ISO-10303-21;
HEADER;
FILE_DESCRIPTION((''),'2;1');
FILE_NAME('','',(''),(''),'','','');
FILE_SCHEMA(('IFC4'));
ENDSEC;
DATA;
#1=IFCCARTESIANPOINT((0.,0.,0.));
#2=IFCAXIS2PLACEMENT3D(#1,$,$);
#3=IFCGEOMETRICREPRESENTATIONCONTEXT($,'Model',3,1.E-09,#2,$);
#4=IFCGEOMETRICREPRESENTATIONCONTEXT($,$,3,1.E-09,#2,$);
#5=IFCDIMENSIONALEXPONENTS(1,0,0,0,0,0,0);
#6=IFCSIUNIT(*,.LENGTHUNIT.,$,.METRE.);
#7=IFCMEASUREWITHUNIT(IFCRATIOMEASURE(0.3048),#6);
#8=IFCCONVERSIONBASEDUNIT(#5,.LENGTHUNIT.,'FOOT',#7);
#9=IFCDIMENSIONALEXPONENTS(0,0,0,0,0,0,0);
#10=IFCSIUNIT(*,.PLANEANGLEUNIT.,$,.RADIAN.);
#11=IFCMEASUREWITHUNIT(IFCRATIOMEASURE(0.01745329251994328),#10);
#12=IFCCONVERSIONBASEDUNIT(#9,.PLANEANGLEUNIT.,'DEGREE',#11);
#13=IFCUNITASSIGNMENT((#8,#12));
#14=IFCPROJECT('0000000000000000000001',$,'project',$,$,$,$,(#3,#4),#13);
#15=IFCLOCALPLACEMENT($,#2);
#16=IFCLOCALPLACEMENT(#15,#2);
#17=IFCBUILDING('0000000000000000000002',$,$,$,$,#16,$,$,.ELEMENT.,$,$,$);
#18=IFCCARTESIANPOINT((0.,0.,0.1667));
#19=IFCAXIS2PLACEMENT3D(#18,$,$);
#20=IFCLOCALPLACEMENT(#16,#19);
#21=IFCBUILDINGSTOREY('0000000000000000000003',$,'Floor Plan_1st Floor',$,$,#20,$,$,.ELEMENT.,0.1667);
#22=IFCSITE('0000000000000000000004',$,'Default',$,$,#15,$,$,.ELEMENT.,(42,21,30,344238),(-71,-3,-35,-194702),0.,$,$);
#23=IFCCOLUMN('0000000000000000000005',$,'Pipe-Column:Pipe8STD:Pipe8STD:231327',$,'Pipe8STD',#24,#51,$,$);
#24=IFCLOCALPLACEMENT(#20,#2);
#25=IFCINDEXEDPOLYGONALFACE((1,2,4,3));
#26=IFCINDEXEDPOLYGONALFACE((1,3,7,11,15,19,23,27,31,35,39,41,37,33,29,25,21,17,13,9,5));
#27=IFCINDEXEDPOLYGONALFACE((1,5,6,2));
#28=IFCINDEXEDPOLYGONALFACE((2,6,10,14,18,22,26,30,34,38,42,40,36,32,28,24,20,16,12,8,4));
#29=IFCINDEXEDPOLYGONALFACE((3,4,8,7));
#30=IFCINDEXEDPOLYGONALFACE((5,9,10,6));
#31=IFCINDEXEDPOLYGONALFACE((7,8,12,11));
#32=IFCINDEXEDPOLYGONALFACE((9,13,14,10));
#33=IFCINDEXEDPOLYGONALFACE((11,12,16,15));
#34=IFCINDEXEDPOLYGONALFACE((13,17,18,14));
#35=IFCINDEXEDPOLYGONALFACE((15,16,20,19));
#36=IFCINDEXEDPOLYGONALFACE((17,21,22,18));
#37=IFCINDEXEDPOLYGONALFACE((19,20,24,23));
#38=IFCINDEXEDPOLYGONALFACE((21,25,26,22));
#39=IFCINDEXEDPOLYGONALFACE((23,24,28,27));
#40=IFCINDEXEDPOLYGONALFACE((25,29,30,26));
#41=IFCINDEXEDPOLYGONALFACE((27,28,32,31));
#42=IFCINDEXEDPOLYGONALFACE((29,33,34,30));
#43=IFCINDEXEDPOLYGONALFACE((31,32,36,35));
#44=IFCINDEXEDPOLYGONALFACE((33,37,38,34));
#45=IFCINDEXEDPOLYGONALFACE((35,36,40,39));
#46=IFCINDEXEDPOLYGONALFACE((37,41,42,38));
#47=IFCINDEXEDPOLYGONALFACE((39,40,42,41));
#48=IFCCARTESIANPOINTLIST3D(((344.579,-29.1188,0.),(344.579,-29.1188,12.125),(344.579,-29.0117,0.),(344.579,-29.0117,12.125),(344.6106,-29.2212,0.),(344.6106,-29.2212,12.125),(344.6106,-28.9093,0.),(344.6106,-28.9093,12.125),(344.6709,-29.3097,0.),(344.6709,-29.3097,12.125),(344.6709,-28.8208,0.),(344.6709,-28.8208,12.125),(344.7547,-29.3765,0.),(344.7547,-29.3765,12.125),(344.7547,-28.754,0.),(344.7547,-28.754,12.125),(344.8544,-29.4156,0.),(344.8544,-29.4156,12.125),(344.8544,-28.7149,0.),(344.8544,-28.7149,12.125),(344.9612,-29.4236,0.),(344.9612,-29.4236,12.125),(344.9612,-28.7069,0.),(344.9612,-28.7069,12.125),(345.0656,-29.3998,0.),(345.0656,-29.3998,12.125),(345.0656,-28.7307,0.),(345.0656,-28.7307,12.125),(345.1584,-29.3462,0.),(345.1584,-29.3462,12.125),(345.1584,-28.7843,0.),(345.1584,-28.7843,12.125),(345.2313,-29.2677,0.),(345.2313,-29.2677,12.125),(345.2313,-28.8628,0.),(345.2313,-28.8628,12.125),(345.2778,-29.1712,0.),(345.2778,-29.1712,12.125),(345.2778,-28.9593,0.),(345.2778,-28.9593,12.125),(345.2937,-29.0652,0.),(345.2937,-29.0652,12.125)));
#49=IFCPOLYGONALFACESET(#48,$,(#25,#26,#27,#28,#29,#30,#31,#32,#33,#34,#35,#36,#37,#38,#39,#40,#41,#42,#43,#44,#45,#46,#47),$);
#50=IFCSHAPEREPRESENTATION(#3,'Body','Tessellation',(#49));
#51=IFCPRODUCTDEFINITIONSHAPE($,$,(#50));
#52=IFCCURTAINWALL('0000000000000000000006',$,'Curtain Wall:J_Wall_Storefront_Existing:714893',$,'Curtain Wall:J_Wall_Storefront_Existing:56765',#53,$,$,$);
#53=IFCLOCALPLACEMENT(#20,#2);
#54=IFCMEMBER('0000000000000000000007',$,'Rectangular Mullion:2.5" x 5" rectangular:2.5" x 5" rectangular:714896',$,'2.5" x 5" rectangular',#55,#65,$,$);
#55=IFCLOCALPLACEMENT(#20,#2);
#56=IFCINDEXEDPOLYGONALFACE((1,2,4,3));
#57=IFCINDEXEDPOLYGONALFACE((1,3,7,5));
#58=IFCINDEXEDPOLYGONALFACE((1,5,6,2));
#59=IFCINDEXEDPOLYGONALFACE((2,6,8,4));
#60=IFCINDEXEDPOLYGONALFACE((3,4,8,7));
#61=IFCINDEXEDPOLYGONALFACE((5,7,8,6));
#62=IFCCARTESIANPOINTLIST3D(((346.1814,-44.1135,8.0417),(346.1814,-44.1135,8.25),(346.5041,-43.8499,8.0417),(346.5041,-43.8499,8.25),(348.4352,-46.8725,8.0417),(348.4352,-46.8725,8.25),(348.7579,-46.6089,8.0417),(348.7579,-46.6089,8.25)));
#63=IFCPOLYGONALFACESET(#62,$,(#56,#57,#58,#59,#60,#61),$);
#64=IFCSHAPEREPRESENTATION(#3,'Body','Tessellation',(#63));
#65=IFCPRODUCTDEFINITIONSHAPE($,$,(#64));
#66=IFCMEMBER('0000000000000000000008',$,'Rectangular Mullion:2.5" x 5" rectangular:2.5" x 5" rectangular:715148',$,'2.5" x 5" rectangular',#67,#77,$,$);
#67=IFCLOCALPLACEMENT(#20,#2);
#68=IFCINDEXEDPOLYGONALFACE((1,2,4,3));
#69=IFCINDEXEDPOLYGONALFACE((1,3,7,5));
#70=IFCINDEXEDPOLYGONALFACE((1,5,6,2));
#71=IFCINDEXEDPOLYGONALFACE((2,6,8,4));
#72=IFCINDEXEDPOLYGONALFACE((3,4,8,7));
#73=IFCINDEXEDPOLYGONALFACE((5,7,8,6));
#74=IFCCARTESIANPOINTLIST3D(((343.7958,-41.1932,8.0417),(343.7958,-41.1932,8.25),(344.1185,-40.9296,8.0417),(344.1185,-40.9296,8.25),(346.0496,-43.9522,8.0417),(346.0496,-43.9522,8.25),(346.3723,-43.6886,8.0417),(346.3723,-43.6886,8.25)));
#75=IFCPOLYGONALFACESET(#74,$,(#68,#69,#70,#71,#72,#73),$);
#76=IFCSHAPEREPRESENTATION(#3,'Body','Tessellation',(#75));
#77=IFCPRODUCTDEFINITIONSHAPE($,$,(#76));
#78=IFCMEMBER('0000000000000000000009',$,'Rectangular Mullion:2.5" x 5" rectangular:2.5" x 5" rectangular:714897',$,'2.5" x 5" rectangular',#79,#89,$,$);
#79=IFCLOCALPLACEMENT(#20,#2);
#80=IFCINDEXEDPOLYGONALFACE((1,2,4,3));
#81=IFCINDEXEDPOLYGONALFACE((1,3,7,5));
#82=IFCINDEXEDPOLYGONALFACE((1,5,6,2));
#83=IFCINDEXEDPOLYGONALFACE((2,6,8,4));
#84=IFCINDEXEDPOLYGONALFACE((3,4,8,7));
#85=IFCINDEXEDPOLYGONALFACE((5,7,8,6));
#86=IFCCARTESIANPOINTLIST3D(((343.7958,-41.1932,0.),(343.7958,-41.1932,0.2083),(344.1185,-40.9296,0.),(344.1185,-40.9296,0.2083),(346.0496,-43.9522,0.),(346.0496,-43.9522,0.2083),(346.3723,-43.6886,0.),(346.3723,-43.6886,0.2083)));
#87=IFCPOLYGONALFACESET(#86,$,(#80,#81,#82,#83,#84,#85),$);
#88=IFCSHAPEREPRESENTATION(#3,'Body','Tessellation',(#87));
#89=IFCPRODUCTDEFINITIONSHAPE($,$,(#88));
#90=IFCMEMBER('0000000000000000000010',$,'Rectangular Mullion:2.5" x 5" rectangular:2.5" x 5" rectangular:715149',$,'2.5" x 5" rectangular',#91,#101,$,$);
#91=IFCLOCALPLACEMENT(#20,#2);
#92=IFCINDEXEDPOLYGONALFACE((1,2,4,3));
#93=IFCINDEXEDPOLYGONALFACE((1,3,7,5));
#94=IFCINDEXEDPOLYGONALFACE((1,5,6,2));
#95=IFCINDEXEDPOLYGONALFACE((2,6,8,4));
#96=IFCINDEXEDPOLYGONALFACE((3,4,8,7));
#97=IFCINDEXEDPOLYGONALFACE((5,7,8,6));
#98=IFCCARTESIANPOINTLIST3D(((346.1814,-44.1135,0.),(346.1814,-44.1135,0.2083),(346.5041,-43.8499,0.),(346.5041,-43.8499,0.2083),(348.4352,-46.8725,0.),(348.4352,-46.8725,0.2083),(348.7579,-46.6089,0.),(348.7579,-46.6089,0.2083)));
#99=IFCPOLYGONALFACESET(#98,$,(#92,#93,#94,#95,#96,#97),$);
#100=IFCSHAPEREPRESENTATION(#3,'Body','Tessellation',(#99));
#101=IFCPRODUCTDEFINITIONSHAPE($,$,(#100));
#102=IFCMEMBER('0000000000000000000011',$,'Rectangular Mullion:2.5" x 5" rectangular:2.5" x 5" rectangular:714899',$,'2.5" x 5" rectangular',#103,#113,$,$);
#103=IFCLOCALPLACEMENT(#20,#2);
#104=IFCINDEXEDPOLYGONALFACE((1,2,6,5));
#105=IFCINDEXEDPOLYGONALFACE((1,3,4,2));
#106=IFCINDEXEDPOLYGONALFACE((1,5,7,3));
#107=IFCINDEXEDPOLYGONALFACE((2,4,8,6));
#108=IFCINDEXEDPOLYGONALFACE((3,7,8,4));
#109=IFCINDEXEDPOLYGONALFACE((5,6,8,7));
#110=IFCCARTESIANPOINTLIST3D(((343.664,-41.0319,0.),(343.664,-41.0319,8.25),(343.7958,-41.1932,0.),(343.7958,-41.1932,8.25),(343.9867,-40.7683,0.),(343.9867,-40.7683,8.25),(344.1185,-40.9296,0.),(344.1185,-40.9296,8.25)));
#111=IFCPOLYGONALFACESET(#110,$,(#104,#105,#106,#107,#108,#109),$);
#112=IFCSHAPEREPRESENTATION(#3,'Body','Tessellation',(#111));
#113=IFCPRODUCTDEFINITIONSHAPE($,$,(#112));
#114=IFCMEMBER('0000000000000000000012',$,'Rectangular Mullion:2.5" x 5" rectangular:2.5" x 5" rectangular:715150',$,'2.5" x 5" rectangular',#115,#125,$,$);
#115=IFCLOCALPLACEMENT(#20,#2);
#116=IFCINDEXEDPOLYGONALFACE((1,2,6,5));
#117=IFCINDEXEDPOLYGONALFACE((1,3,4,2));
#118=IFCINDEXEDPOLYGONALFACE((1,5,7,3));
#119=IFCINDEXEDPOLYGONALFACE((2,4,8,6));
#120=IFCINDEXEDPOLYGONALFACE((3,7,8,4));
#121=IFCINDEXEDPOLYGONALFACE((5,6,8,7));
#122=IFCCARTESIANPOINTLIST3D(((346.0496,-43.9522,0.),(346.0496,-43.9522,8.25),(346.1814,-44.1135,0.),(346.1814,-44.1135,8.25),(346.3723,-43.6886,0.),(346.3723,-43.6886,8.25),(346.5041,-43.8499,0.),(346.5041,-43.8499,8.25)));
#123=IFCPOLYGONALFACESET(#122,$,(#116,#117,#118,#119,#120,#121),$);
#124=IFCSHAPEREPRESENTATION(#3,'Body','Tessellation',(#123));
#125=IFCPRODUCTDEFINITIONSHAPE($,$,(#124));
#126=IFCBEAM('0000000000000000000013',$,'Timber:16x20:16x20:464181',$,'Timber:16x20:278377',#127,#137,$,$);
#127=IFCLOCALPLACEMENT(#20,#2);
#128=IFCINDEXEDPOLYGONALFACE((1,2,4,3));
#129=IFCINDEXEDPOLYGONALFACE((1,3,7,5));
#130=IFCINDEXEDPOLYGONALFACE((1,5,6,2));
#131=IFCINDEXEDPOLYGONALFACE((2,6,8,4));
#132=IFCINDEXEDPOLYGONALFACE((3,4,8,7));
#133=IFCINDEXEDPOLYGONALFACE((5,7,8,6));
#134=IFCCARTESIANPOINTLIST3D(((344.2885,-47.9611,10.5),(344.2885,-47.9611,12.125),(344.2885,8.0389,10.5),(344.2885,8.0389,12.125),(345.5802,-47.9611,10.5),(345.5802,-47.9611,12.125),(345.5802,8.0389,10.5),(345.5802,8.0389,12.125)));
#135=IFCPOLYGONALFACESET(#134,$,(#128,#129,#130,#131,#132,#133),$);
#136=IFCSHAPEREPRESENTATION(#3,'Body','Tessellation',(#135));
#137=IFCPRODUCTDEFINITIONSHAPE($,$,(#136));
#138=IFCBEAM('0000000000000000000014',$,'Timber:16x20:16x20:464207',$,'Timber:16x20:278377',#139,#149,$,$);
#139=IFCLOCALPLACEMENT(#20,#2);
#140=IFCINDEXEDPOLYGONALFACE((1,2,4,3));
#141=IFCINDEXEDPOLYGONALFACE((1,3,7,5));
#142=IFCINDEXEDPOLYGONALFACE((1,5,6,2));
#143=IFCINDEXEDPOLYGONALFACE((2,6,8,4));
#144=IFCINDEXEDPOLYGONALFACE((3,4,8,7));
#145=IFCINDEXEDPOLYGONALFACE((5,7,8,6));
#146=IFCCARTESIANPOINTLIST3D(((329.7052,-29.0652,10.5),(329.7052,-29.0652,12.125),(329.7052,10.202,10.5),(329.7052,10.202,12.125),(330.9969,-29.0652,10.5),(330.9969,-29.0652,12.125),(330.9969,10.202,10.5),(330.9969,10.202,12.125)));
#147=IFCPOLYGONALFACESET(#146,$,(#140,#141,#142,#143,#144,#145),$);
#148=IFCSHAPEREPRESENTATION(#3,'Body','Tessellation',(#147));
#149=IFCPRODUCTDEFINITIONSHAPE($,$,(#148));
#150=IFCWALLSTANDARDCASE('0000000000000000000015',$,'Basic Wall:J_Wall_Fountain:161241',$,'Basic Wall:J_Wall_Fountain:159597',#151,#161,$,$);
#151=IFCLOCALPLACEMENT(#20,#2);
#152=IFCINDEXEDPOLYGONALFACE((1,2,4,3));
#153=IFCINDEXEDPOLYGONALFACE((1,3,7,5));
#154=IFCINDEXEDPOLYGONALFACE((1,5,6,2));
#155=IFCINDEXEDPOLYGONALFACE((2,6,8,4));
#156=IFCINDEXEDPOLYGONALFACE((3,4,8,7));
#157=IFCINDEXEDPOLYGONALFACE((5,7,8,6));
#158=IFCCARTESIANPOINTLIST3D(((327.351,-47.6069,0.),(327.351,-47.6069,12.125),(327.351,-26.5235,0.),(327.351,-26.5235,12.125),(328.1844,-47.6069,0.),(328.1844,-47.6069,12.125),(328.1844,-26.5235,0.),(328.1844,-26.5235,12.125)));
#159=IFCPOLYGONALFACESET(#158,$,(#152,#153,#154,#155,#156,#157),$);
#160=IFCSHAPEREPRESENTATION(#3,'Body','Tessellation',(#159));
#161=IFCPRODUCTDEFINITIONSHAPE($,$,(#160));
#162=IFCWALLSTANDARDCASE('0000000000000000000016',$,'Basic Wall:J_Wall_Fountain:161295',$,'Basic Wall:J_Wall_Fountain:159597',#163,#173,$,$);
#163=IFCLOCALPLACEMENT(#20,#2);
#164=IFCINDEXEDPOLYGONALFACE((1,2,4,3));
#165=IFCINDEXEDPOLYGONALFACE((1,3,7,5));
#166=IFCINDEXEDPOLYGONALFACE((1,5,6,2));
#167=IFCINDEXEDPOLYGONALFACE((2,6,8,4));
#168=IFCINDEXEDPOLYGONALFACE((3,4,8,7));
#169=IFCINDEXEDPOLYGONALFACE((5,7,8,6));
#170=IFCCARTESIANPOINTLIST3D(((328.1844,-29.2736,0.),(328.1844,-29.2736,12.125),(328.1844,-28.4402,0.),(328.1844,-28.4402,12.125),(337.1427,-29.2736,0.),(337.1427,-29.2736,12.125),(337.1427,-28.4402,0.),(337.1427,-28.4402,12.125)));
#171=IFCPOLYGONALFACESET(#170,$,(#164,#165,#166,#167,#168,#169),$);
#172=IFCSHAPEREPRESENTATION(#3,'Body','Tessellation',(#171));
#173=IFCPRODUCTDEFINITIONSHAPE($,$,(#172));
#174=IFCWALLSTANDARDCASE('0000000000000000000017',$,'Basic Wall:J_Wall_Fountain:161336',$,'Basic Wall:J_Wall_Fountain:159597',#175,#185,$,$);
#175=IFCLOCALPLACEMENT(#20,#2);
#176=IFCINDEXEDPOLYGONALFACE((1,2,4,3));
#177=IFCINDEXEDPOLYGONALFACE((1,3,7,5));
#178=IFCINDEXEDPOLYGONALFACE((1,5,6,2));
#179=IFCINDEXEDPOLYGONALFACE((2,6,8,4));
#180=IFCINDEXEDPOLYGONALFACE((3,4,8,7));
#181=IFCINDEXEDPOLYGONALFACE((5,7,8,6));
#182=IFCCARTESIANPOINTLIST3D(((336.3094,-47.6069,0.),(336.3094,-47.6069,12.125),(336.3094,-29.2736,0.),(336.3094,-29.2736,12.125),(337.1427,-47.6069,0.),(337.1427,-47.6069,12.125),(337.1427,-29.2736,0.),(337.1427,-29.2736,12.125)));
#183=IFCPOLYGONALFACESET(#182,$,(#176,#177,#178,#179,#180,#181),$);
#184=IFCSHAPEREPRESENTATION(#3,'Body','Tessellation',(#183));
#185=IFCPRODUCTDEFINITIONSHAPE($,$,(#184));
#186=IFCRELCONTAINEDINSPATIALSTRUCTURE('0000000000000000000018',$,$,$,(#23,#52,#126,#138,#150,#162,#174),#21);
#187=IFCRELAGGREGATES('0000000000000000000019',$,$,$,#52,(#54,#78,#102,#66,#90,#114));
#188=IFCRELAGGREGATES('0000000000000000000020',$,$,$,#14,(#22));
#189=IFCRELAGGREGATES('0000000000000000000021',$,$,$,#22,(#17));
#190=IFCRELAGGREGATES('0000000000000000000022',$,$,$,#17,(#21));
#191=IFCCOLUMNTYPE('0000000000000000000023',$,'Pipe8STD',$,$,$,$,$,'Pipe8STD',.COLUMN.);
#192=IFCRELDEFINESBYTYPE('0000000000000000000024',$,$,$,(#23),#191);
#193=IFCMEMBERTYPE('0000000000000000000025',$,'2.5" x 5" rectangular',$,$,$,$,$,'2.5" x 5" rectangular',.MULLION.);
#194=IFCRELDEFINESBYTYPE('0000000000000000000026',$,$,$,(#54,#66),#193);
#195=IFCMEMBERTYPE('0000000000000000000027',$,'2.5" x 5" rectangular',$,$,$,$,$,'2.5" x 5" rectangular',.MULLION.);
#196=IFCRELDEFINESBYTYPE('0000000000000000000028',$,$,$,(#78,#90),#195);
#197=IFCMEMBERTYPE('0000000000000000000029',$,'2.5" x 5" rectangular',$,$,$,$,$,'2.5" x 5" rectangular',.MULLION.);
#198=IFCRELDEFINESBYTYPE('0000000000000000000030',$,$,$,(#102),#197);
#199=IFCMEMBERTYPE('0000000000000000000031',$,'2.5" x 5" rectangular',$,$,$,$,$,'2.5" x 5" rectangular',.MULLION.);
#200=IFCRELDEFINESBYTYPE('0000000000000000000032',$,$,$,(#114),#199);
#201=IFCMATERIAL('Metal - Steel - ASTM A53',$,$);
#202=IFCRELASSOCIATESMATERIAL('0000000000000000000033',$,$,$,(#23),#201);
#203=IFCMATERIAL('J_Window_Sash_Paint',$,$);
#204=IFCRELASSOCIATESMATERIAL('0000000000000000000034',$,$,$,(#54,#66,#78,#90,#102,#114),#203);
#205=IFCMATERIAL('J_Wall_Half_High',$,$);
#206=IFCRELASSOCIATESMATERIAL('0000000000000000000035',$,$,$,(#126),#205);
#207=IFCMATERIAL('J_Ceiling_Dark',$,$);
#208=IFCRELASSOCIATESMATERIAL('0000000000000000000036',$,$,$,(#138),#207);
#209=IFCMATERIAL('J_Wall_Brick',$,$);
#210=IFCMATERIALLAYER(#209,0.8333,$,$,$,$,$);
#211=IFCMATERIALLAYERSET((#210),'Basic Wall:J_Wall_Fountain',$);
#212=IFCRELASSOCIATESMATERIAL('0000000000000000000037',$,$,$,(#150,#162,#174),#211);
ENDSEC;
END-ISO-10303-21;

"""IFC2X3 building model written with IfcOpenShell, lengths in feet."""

from ifc_helpers import new_model, entity, si_unit, converted_unit, frame, frame_2d, origin, origin_2d_with_axis, place, context, project, spatial, rectangle, circle, extrude, source, transform, mapped, material, layer, layer_set, layer_usage, type_object, type_shapes, element, aggregate, save


model = new_model("IFC2X3")

# Units and contexts
model_context = context("Model", 3, precision=1e-09, world=origin())
context_of_model = context(None, 3, precision=1e-09, world=origin())
ifc_project = project(units=[converted_unit("LENGTHUNIT", "FOOT", entity("IfcRatioMeasure", 0.3048), si_unit("LENGTHUNIT", "METRE"), dimensions=[1, 0, 0, 0, 0, 0, 0]), converted_unit("PLANEANGLEUNIT", "DEGREE", entity("IfcRatioMeasure", 0.01745329251994328), si_unit("PLANEANGLEUNIT", "RADIAN"), dimensions=[0, 0, 0, 0, 0, 0, 0])], contexts=[model_context, context_of_model])

# Site, building, storey
site_placement = place(None, origin())
site = spatial("IfcSite", under=ifc_project, at=site_placement, Name="Default", CompositionType="ELEMENT", RefLatitude=(42, 21, 30, 344238), RefLongitude=(-71, -3, -35, -194702), RefElevation=0.0)
building_placement = place(site_placement, origin())
building = spatial("IfcBuilding", under=site, at=building_placement, CompositionType="ELEMENT")
storey_placement = place(building_placement, frame((0.0, 0.0, 0.1667)))
storey = spatial("IfcBuildingStorey", under=building, at=storey_placement, Name="Floor Plan_1st Floor", CompositionType="ELEMENT", Elevation=0.1667)

# Column
ifc_material_1 = material(Name="Metal - Steel - ASTM A53")
column_type = type_object("IfcColumnType", Name="Pipe8STD", ElementType="Pipe8STD", PredefinedType="COLUMN")
shared_shape_1 = source(origin(), model_context, "Body", "SweptSolid", [
    extrude(circle(Radius=0.3594, at=origin_2d_with_axis()), origin(), (0.0, 0.0, 1.0), 12.125),
])
type_shapes(column_type, [shared_shape_1])
column_placement = place(storey_placement, frame((344.9344, -29.0652, 0.0)))
element("IfcColumn", 1, at=column_placement, inside=storey, type_object=column_type, material=ifc_material_1, Name="Pipe-Column:Pipe8STD:Pipe8STD:231327", ObjectType="Pipe8STD", context=model_context, shape_type="MappedRepresentation", body=[
    mapped(shared_shape_1, transform((0.0, 0.0, 0.0), scale=1.0)),
])

# Curtain wall, members
curtain_wall_placement = place(storey_placement, origin())
curtain_wall = element("IfcCurtainWall", 2, at=curtain_wall_placement, inside=storey, Name="Curtain Wall:J_Wall_Storefront_Existing:714893", ObjectType="Curtain Wall:J_Wall_Storefront_Existing:56765")
ifc_material_2 = material(Name="J_Window_Sash_Paint")
member_type_1 = type_object("IfcMemberType", Name="2.5\" x 5\" rectangular", ElementType="2.5\" x 5\" rectangular", PredefinedType="MULLION")
shared_shape_2 = source(origin(), model_context, "Body", "SweptSolid", [
    extrude(rectangle(XDim=0.2083, YDim=0.4167, at=origin_2d_with_axis()), frame((-0.1042, 0.0, -3.5625), z_axis=(0.0, 0.0, 1.0), x_axis=(-1.0, 0.0, 0.0)), (0.0, 0.0, 1.0), 3.5625),
])
type_shapes(member_type_1, [shared_shape_2])
member_1_placement = place(storey_placement, frame((348.5965, -46.7407, 8.25), z_axis=(0.632643, -0.774444, 0.0), x_axis=(0.0, 0.0, 1.0)))
member_1 = element("IfcMember", 3, at=member_1_placement, type_object=member_type_1, material=ifc_material_2, Name="Rectangular Mullion:2.5\" x 5\" rectangular:2.5\" x 5\" rectangular:714896", ObjectType="2.5\" x 5\" rectangular", context=model_context, shape_type="MappedRepresentation", body=[
    mapped(shared_shape_2, transform((0.0, 0.0, 0.0), scale=1.0)),
])
member_2_placement = place(storey_placement, frame((346.2109, -43.8204, 8.25), z_axis=(0.632643, -0.774444, 0.0), x_axis=(0.0, 0.0, 1.0)))
member_2 = element("IfcMember", 4, at=member_2_placement, type_object=member_type_1, material=ifc_material_2, Name="Rectangular Mullion:2.5\" x 5\" rectangular:2.5\" x 5\" rectangular:715148", ObjectType="2.5\" x 5\" rectangular", context=model_context, shape_type="MappedRepresentation", body=[
    mapped(shared_shape_2, transform((0.0, 0.0, 0.0), scale=1.0)),
])
member_type_2 = type_object("IfcMemberType", Name="2.5\" x 5\" rectangular", ElementType="2.5\" x 5\" rectangular", PredefinedType="MULLION")
shared_shape_3 = source(origin(), model_context, "Body", "SweptSolid", [
    extrude(rectangle(XDim=0.2083, YDim=0.4167, at=origin_2d_with_axis()), frame((-0.1042, 0.0, -3.5625), z_axis=(0.0, 0.0, 1.0), x_axis=(-1.0, 0.0, 0.0)), (0.0, 0.0, 1.0), 3.5625),
])
type_shapes(member_type_2, [shared_shape_3])
member_3_placement = place(storey_placement, frame((343.9571, -41.0614, 0.0), z_axis=(-0.632643, 0.774444, 0.0), x_axis=(0.0, 0.0, -1.0)))
member_3 = element("IfcMember", 5, at=member_3_placement, type_object=member_type_2, material=ifc_material_2, Name="Rectangular Mullion:2.5\" x 5\" rectangular:2.5\" x 5\" rectangular:714897", ObjectType="2.5\" x 5\" rectangular", context=model_context, shape_type="MappedRepresentation", body=[
    mapped(shared_shape_3, transform((0.0, 0.0, 0.0), scale=1.0)),
])
member_4_placement = place(storey_placement, frame((346.3427, -43.9817, 0.0), z_axis=(-0.632643, 0.774444, 0.0), x_axis=(0.0, 0.0, -1.0)))
member_4 = element("IfcMember", 6, at=member_4_placement, type_object=member_type_2, material=ifc_material_2, Name="Rectangular Mullion:2.5\" x 5\" rectangular:2.5\" x 5\" rectangular:715149", ObjectType="2.5\" x 5\" rectangular", context=model_context, shape_type="MappedRepresentation", body=[
    mapped(shared_shape_3, transform((0.0, 0.0, 0.0), scale=1.0)),
])
member_type_3 = type_object("IfcMemberType", Name="2.5\" x 5\" rectangular", ElementType="2.5\" x 5\" rectangular", PredefinedType="MULLION")
shared_shape_4 = source(origin(), model_context, "Body", "SweptSolid", [
    extrude(rectangle(XDim=0.2083, YDim=0.4167, at=origin_2d_with_axis()), frame((-0.1042, 0.0, -8.25), z_axis=(0.0, 0.0, 1.0), x_axis=(-1.0, 0.0, 0.0)), (0.0, 0.0, 1.0), 8.25),
])
type_shapes(member_type_3, [shared_shape_4])
member_5_placement = place(storey_placement, frame((343.8253, -40.9001, 8.25), z_axis=(0.0, 0.0, 1.0), x_axis=(-0.632643, 0.774444, 0.0)))
member_5 = element("IfcMember", 7, at=member_5_placement, type_object=member_type_3, material=ifc_material_2, Name="Rectangular Mullion:2.5\" x 5\" rectangular:2.5\" x 5\" rectangular:714899", ObjectType="2.5\" x 5\" rectangular", context=model_context, shape_type="MappedRepresentation", body=[
    mapped(shared_shape_4, transform((0.0, 0.0, 0.0), scale=1.0)),
])
member_type_4 = type_object("IfcMemberType", Name="2.5\" x 5\" rectangular", ElementType="2.5\" x 5\" rectangular", PredefinedType="MULLION")
shared_shape_5 = source(origin(), model_context, "Body", "SweptSolid", [
    extrude(rectangle(XDim=0.2083, YDim=0.4167, at=origin_2d_with_axis()), frame((0.0, 0.0, -8.25), z_axis=(0.0, 0.0, 1.0), x_axis=(-1.0, 0.0, 0.0)), (0.0, 0.0, 1.0), 8.25),
])
type_shapes(member_type_4, [shared_shape_5])
member_6_placement = place(storey_placement, frame((346.2768, -43.9011, 0.0), z_axis=(0.0, 0.0, -1.0), x_axis=(0.632643, -0.774444, 0.0)))
member_6 = element("IfcMember", 8, at=member_6_placement, type_object=member_type_4, material=ifc_material_2, Name="Rectangular Mullion:2.5\" x 5\" rectangular:2.5\" x 5\" rectangular:715150", ObjectType="2.5\" x 5\" rectangular", context=model_context, shape_type="MappedRepresentation", body=[
    mapped(shared_shape_5, transform((0.0, 0.0, 0.0), scale=1.0)),
])

# Beams
ifc_material_3 = material(Name="J_Wall_Half_High")
beam_1_placement = place(storey_placement, frame((344.9344, -29.0652, 12.125), z_axis=(0.0, 0.0, 1.0), x_axis=(-1.0, 0.0, 0.0)))
element("IfcBeam", 9, at=beam_1_placement, inside=storey, material=ifc_material_3, Name="Timber:16x20:16x20:464181", ObjectType="Timber:16x20:278377", context=model_context, shape_type="SweptSolid", body=[
    extrude(rectangle(XDim=1.625, YDim=56.0, at=frame_2d((0.0, 0.0), x_axis=(0.0, 1.0))), frame((0.6458, -9.1042, -0.8125), z_axis=(-1.0, 0.0, 0.0), x_axis=(0.0, -1.0, 0.0)), (0.0, 0.0, 1.0), 1.2917),
])
ifc_material_4 = material(Name="J_Ceiling_Dark")
beam_2_placement = place(storey_placement, frame((330.351, -29.0652, 12.125), z_axis=(0.0, 0.0, 1.0), x_axis=(-1.0, 0.0, 0.0)))
element("IfcBeam", 10, at=beam_2_placement, inside=storey, material=ifc_material_4, Name="Timber:16x20:16x20:464207", ObjectType="Timber:16x20:278377", context=model_context, shape_type="SweptSolid", body=[
    extrude(rectangle(XDim=1.625, YDim=39.2672, at=frame_2d((0.0, 0.0), x_axis=(0.0, 1.0))), frame((0.6458, -19.6336, -0.8125), z_axis=(-1.0, 0.0, 0.0), x_axis=(0.0, -1.0, 0.0)), (0.0, 0.0, 1.0), 1.2917),
])

aggregate(curtain_wall, [member_1, member_3, member_5, member_2, member_4, member_6])

# Walls
ifc_material_5 = material(Name="J_Wall_Brick")
ifc_layer_1 = layer(ifc_material_5, 0.8333)
ifc_layer_set_1 = layer_set([ifc_layer_1], Name="Basic Wall:J_Wall_Fountain")
ifc_layer_usage_1 = layer_usage(ifc_layer_set_1, "AXIS2", "NEGATIVE", 0.4167)
wall_1_placement = place(storey_placement, frame((327.7677, -26.5235, 0.0), z_axis=(0.0, 0.0, 1.0), x_axis=(0.0, -1.0, 0.0)))
element("IfcWallStandardCase", 11, at=wall_1_placement, inside=storey, material=ifc_layer_usage_1, Name="Basic Wall:J_Wall_Fountain:161241", ObjectType="Basic Wall:J_Wall_Fountain:159597", context=model_context, shape_type="SweptSolid", body=[
    extrude(rectangle(XDim=21.0834, YDim=0.8333, at=frame_2d((10.5417, 0.0), x_axis=(-1.0, 0.0))), origin(), (0.0, 0.0, 1.0), 12.125),
])
ifc_layer_usage_2 = layer_usage(ifc_layer_set_1, "AXIS2", "NEGATIVE", 0.4167)
wall_2_placement = place(storey_placement, frame((328.1844, -28.8569, 0.0)))
element("IfcWallStandardCase", 12, at=wall_2_placement, inside=storey, material=ifc_layer_usage_2, Name="Basic Wall:J_Wall_Fountain:161295", ObjectType="Basic Wall:J_Wall_Fountain:159597", context=model_context, shape_type="SweptSolid", body=[
    extrude(rectangle(XDim=8.9583, YDim=0.8333, at=frame_2d((4.4792, 0.0), x_axis=(-1.0, 0.0))), origin(), (0.0, 0.0, 1.0), 12.125),
])
ifc_layer_usage_3 = layer_usage(ifc_layer_set_1, "AXIS2", "NEGATIVE", 0.4167)
wall_3_placement = place(storey_placement, frame((336.726, -29.2736, 0.0), z_axis=(0.0, 0.0, 1.0), x_axis=(0.0, -1.0, 0.0)))
element("IfcWallStandardCase", 13, at=wall_3_placement, inside=storey, material=ifc_layer_usage_3, Name="Basic Wall:J_Wall_Fountain:161336", ObjectType="Basic Wall:J_Wall_Fountain:159597", context=model_context, shape_type="SweptSolid", body=[
    extrude(rectangle(XDim=18.3333, YDim=0.8333, at=frame_2d((9.1667, 0.0), x_axis=(-1.0, 0.0))), origin(), (0.0, 0.0, 1.0), 12.125),
])

save(model, "model.ifc")
